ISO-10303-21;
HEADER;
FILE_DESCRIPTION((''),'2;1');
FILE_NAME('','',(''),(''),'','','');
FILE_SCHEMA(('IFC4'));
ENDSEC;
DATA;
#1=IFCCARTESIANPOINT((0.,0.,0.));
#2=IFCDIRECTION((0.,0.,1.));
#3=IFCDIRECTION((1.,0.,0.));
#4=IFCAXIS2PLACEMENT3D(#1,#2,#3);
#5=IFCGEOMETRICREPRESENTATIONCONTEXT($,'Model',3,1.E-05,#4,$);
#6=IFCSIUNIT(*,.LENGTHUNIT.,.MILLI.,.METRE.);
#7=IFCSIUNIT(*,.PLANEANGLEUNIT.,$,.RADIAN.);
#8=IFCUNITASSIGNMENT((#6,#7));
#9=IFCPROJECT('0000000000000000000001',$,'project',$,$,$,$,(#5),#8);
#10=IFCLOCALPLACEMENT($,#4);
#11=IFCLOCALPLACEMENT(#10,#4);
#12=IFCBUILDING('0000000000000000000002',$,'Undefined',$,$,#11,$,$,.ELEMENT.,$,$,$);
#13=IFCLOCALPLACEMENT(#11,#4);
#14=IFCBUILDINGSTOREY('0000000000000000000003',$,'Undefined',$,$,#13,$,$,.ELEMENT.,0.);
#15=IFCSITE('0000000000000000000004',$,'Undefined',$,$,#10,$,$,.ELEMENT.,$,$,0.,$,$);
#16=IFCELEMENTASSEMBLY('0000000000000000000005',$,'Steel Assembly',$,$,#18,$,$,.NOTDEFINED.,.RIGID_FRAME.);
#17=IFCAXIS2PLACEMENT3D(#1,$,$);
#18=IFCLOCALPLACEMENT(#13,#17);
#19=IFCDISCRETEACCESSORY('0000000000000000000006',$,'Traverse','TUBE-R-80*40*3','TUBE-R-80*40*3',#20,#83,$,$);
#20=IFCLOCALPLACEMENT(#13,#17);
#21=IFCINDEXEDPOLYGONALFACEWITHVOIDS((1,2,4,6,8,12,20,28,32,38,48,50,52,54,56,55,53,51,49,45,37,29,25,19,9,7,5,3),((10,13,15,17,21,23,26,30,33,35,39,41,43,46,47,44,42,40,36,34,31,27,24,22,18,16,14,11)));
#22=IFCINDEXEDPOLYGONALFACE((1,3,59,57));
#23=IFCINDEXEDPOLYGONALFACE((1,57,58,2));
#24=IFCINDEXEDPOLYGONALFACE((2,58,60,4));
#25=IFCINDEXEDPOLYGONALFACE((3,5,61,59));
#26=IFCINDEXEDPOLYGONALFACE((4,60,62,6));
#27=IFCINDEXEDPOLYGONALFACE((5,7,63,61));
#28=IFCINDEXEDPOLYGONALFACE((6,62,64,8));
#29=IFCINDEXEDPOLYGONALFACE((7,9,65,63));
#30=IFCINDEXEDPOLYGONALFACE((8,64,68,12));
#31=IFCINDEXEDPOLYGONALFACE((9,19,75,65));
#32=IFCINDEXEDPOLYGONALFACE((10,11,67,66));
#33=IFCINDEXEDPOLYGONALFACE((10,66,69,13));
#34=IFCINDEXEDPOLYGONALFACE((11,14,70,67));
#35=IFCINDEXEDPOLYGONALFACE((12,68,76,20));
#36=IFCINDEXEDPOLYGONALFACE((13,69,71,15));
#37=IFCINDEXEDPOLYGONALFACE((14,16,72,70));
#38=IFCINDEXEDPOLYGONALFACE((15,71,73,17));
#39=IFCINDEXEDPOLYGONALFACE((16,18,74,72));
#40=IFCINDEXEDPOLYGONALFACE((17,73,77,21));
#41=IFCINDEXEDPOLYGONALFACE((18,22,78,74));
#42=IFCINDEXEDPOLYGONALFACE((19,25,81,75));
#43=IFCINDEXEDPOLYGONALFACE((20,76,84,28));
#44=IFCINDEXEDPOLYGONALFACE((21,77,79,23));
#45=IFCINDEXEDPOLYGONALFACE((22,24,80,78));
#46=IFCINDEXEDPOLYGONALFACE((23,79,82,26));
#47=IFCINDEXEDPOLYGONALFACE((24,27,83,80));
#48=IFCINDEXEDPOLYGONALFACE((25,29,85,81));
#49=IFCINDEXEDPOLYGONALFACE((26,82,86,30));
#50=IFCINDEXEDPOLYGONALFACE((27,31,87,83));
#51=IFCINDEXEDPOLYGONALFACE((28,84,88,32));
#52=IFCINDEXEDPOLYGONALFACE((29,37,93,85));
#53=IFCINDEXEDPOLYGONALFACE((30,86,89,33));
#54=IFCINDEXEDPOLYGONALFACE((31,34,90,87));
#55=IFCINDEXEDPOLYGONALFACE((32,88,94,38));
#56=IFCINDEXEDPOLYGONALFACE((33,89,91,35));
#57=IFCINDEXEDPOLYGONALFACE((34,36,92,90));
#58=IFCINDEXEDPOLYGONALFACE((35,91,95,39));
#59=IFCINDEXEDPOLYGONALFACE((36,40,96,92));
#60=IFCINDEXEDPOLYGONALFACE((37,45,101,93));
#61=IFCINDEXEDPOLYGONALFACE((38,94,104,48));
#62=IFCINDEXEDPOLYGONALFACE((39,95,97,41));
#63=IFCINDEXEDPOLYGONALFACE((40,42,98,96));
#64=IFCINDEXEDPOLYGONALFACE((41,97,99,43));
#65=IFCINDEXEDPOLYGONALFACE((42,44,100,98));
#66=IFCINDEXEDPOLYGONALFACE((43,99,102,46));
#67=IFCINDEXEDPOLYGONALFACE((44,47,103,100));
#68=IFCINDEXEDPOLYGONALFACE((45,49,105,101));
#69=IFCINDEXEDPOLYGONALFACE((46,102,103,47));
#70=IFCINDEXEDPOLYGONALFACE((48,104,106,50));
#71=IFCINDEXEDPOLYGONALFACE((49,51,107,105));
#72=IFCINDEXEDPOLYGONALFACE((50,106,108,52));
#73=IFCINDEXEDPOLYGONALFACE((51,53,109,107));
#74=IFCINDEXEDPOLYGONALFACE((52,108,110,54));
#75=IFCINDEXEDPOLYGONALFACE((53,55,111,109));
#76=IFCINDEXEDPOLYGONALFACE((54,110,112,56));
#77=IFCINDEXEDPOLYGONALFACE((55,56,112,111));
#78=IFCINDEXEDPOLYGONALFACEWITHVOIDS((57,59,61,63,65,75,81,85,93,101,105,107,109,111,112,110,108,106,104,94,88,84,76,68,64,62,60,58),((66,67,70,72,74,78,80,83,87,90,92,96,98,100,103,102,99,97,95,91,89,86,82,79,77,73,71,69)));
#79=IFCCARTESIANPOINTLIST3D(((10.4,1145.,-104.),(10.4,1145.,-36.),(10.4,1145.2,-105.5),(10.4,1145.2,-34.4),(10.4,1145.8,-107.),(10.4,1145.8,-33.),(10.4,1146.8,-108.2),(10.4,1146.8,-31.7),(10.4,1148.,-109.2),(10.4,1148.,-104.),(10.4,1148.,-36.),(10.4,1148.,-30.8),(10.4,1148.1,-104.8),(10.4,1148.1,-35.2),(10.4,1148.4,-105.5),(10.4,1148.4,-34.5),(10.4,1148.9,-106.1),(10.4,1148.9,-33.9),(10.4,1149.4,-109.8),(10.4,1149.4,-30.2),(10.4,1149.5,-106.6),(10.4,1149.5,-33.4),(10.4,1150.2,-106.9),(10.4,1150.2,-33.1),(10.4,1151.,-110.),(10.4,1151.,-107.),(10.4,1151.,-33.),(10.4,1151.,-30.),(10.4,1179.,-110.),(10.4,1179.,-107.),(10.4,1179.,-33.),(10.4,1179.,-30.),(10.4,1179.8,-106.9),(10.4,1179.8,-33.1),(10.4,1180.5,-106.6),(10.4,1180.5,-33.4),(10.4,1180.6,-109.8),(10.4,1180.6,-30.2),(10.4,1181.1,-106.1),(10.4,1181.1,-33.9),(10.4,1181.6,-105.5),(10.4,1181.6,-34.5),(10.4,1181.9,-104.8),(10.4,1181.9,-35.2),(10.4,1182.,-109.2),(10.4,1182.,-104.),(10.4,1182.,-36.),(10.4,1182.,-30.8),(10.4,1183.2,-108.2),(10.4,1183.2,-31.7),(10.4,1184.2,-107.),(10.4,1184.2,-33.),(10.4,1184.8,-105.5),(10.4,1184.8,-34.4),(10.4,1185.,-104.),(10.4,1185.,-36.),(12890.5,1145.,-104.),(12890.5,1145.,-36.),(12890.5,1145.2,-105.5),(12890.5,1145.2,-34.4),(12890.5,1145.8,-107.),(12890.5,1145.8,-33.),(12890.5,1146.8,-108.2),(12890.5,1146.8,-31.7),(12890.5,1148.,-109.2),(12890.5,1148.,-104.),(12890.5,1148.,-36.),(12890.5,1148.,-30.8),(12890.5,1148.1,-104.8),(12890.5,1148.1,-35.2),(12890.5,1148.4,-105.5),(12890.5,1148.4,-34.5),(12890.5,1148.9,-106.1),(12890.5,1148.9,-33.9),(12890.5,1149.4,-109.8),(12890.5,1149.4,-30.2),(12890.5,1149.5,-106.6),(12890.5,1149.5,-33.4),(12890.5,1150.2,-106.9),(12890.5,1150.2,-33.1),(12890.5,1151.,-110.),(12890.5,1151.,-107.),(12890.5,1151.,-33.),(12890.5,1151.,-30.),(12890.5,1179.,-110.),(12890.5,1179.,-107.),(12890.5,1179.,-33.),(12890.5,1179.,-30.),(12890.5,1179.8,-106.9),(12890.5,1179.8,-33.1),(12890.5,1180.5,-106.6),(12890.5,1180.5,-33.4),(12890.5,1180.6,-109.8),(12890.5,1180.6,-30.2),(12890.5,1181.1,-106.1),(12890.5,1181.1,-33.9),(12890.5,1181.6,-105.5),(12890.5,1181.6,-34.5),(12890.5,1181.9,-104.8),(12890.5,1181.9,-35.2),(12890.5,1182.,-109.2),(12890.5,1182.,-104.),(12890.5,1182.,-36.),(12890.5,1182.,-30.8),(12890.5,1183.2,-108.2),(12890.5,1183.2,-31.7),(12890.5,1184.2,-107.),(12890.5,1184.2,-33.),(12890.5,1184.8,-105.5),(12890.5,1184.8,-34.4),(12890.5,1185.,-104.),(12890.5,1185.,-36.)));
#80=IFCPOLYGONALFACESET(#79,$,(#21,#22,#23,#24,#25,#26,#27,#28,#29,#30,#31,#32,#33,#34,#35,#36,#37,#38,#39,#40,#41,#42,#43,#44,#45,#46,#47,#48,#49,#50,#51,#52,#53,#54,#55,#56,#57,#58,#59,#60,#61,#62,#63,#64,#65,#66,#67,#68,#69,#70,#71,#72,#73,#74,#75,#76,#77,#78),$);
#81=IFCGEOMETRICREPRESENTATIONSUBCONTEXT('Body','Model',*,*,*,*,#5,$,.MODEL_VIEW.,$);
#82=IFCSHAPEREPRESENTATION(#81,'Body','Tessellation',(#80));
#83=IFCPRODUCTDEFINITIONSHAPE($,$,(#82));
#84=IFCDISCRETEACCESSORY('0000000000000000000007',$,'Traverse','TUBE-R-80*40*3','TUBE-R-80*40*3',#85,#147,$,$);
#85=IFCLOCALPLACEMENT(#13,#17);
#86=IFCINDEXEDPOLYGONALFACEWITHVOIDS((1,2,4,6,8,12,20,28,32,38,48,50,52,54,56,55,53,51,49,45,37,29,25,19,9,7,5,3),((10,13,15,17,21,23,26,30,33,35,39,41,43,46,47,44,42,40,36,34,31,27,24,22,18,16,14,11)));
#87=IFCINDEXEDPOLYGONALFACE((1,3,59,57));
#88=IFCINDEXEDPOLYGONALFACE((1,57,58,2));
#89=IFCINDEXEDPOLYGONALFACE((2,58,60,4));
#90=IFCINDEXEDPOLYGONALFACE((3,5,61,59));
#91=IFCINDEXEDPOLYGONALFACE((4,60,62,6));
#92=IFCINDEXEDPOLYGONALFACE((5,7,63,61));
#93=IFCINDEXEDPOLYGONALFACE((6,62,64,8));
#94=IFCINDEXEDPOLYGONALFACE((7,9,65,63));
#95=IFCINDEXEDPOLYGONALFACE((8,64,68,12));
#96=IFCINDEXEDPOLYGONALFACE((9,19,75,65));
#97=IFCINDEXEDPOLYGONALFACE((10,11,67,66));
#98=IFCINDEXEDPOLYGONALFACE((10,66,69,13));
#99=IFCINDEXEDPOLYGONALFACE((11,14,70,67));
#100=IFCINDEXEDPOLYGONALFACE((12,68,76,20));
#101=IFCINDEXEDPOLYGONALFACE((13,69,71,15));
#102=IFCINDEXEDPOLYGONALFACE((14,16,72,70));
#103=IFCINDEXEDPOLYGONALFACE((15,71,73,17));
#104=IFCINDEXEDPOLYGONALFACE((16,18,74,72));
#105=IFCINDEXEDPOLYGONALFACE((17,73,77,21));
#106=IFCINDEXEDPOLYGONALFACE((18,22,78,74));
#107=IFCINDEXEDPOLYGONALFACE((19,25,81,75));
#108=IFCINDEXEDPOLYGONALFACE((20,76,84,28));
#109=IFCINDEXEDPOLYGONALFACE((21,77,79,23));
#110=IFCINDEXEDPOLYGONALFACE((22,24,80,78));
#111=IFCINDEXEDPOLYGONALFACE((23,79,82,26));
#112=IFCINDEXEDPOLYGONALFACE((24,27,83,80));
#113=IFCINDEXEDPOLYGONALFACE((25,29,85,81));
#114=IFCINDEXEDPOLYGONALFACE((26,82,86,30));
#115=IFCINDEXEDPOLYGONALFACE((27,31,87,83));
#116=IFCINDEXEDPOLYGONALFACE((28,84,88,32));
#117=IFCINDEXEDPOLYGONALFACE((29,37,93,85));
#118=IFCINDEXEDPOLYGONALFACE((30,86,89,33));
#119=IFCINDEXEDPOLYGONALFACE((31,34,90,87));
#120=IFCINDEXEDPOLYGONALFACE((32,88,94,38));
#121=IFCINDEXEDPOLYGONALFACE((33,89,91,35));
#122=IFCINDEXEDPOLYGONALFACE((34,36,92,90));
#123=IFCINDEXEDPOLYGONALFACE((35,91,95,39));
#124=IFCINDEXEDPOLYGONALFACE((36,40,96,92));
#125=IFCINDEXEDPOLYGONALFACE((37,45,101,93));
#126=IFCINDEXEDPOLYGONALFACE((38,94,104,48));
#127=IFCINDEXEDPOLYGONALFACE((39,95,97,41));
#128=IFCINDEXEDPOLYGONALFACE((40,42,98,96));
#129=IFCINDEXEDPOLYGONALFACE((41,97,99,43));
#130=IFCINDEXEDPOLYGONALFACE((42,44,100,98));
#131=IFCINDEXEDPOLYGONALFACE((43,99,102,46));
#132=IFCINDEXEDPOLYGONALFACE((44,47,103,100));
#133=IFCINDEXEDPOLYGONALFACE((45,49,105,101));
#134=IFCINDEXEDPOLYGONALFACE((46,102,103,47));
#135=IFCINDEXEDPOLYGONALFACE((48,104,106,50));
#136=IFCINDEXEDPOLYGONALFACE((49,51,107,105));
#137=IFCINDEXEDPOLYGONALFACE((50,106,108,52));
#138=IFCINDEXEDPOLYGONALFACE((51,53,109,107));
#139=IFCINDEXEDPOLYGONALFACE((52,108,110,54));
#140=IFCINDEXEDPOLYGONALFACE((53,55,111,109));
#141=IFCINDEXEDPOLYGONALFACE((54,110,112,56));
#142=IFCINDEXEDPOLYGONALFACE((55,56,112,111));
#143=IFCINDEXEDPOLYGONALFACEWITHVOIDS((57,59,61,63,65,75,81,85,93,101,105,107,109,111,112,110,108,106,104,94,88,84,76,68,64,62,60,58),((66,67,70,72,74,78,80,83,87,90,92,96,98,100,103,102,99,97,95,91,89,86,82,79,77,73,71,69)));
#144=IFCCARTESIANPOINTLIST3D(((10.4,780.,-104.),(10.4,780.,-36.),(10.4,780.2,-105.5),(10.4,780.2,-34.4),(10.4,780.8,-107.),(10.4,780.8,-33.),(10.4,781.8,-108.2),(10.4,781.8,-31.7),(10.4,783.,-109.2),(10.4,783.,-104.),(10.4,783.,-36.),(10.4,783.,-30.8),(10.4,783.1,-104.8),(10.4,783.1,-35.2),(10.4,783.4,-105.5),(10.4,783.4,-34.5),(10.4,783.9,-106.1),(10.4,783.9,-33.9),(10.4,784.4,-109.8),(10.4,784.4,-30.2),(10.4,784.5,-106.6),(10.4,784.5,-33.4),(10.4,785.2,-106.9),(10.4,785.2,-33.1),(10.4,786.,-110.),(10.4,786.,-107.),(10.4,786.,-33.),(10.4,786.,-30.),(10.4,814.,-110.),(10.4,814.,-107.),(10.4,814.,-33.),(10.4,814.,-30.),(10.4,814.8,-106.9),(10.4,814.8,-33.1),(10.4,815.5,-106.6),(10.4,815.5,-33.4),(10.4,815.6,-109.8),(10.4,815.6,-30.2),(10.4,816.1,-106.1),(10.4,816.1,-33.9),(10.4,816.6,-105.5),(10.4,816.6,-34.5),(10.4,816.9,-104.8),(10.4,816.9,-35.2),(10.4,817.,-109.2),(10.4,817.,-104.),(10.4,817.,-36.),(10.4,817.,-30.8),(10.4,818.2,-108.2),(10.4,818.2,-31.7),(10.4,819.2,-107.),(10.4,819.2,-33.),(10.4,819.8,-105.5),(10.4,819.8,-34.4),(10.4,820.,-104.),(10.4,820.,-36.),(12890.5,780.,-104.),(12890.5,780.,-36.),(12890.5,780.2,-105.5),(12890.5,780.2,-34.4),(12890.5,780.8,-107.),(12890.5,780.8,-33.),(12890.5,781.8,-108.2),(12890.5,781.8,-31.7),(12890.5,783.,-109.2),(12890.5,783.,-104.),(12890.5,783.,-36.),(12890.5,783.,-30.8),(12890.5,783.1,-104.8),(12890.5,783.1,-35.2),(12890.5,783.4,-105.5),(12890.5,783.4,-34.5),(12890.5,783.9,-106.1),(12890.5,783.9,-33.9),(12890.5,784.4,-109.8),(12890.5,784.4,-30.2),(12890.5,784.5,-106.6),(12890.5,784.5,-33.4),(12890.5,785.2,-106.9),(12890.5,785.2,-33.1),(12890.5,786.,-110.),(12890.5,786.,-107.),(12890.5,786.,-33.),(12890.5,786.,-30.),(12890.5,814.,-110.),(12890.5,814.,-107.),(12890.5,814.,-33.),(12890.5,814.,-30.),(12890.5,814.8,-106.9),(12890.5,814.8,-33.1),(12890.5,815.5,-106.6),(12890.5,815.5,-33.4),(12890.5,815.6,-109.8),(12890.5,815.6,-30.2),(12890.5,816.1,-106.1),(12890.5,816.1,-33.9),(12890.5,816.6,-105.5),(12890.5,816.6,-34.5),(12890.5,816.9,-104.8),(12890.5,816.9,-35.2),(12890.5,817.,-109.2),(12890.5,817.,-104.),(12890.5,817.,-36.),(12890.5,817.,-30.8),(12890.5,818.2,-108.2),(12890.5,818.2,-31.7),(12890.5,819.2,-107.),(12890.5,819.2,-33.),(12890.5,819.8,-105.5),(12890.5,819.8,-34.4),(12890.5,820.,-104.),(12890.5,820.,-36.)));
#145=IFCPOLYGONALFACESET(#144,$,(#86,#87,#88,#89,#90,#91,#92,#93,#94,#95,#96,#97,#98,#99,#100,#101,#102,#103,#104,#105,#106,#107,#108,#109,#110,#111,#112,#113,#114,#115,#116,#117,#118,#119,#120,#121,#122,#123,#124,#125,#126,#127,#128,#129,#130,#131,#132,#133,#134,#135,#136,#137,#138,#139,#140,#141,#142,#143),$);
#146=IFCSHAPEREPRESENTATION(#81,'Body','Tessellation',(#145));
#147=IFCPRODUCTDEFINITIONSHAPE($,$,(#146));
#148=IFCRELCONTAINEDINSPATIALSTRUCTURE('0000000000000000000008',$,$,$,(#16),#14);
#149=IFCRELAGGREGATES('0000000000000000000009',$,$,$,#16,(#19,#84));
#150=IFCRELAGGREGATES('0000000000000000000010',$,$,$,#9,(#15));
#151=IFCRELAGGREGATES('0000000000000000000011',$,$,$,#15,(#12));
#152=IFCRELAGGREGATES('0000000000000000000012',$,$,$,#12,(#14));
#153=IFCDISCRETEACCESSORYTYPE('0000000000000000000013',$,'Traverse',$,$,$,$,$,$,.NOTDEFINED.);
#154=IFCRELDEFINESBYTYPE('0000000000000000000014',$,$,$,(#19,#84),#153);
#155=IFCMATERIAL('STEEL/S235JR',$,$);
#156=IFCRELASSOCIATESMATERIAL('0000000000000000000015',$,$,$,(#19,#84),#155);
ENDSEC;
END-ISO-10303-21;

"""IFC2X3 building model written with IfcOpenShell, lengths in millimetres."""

from ifc_helpers import new_model, si_unit, frame, origin_with_axes, origin_2d_with_axis, place, context, subcontext, project, spatial, hollow_rectangle, extrude, material, type_object, element, aggregate, save


model = new_model("IFC2X3")

# Units and contexts
model_context = context("Model", 3, precision=1e-05, world=origin_with_axes())
body_context = subcontext(model_context, "Body", "Model", "MODEL_VIEW")
ifc_project = project(units=[si_unit("LENGTHUNIT", "METRE", prefix="MILLI"), si_unit("PLANEANGLEUNIT", "RADIAN")], contexts=[model_context])

# Site, building, storey
site_placement = place(None, origin_with_axes())
site = spatial("IfcSite", under=ifc_project, at=site_placement, Name="Undefined", CompositionType="ELEMENT", RefElevation=0.0)
building_placement = place(site_placement, origin_with_axes())
building = spatial("IfcBuilding", under=site, at=building_placement, Name="Undefined", CompositionType="ELEMENT")
storey_placement = place(building_placement, origin_with_axes())
storey = spatial("IfcBuildingStorey", under=building, at=storey_placement, Name="Undefined", CompositionType="ELEMENT", Elevation=0.0)

# Shared definitions
ifc_material_1 = material(Name="STEEL/S235JR")

# Element assembly
assembly_1_placement = place(storey_placement, origin_with_axes())
assembly_1 = element("IfcElementAssembly", 1, at=assembly_1_placement, inside=storey, Name="Steel Assembly", AssemblyPlace="NOTDEFINED", PredefinedType="RIGID_FRAME")
discrete_accessory_type_1 = type_object("IfcDiscreteAccessoryType", Name="Traverse")

# Discrete accessories
discrete_accessory_1_placement = place(assembly_1_placement, frame((10.4, 1165.0, -70.0), z_axis=(0.0, 0.0, 1.0), x_axis=(1.0, 0.0, 0.0)))
discrete_accessory_1 = element("IfcDiscreteAccessory", 2, at=discrete_accessory_1_placement, type_object=discrete_accessory_type_1, material=ifc_material_1, Name="Traverse", Description="TUBE-R-80*40*3", ObjectType="TUBE-R-80*40*3", context=body_context, shape_type="SweptSolid", body=[
    extrude(hollow_rectangle(XDim=40.0, YDim=80.0, WallThickness=3.0, InnerFilletRadius=3.0, OuterFilletRadius=6.0, at=origin_2d_with_axis()), frame((12880.1, 0.0, 0.0), z_axis=(-1.0, 0.0, 0.0), x_axis=(0.0, -1.0, 0.0)), (0.0, 0.0, 1.0), 12880.1),
])
discrete_accessory_2_placement = place(assembly_1_placement, frame((10.4, 800.0, -70.0), z_axis=(0.0, 0.0, 1.0), x_axis=(1.0, 0.0, 0.0)))
discrete_accessory_2 = element("IfcDiscreteAccessory", 3, at=discrete_accessory_2_placement, type_object=discrete_accessory_type_1, material=ifc_material_1, Name="Traverse", Description="TUBE-R-80*40*3", ObjectType="TUBE-R-80*40*3", context=body_context, shape_type="SweptSolid", body=[
    extrude(hollow_rectangle(XDim=40.0, YDim=80.0, WallThickness=3.0, InnerFilletRadius=3.0, OuterFilletRadius=6.0, at=origin_2d_with_axis()), frame((12880.1, 0.0, 0.0), z_axis=(-1.0, 0.0, 0.0), x_axis=(0.0, -1.0, 0.0)), (0.0, 0.0, 1.0), 12880.1),
])

aggregate(assembly_1, [discrete_accessory_1, discrete_accessory_2])

save(model, "model.ifc")
